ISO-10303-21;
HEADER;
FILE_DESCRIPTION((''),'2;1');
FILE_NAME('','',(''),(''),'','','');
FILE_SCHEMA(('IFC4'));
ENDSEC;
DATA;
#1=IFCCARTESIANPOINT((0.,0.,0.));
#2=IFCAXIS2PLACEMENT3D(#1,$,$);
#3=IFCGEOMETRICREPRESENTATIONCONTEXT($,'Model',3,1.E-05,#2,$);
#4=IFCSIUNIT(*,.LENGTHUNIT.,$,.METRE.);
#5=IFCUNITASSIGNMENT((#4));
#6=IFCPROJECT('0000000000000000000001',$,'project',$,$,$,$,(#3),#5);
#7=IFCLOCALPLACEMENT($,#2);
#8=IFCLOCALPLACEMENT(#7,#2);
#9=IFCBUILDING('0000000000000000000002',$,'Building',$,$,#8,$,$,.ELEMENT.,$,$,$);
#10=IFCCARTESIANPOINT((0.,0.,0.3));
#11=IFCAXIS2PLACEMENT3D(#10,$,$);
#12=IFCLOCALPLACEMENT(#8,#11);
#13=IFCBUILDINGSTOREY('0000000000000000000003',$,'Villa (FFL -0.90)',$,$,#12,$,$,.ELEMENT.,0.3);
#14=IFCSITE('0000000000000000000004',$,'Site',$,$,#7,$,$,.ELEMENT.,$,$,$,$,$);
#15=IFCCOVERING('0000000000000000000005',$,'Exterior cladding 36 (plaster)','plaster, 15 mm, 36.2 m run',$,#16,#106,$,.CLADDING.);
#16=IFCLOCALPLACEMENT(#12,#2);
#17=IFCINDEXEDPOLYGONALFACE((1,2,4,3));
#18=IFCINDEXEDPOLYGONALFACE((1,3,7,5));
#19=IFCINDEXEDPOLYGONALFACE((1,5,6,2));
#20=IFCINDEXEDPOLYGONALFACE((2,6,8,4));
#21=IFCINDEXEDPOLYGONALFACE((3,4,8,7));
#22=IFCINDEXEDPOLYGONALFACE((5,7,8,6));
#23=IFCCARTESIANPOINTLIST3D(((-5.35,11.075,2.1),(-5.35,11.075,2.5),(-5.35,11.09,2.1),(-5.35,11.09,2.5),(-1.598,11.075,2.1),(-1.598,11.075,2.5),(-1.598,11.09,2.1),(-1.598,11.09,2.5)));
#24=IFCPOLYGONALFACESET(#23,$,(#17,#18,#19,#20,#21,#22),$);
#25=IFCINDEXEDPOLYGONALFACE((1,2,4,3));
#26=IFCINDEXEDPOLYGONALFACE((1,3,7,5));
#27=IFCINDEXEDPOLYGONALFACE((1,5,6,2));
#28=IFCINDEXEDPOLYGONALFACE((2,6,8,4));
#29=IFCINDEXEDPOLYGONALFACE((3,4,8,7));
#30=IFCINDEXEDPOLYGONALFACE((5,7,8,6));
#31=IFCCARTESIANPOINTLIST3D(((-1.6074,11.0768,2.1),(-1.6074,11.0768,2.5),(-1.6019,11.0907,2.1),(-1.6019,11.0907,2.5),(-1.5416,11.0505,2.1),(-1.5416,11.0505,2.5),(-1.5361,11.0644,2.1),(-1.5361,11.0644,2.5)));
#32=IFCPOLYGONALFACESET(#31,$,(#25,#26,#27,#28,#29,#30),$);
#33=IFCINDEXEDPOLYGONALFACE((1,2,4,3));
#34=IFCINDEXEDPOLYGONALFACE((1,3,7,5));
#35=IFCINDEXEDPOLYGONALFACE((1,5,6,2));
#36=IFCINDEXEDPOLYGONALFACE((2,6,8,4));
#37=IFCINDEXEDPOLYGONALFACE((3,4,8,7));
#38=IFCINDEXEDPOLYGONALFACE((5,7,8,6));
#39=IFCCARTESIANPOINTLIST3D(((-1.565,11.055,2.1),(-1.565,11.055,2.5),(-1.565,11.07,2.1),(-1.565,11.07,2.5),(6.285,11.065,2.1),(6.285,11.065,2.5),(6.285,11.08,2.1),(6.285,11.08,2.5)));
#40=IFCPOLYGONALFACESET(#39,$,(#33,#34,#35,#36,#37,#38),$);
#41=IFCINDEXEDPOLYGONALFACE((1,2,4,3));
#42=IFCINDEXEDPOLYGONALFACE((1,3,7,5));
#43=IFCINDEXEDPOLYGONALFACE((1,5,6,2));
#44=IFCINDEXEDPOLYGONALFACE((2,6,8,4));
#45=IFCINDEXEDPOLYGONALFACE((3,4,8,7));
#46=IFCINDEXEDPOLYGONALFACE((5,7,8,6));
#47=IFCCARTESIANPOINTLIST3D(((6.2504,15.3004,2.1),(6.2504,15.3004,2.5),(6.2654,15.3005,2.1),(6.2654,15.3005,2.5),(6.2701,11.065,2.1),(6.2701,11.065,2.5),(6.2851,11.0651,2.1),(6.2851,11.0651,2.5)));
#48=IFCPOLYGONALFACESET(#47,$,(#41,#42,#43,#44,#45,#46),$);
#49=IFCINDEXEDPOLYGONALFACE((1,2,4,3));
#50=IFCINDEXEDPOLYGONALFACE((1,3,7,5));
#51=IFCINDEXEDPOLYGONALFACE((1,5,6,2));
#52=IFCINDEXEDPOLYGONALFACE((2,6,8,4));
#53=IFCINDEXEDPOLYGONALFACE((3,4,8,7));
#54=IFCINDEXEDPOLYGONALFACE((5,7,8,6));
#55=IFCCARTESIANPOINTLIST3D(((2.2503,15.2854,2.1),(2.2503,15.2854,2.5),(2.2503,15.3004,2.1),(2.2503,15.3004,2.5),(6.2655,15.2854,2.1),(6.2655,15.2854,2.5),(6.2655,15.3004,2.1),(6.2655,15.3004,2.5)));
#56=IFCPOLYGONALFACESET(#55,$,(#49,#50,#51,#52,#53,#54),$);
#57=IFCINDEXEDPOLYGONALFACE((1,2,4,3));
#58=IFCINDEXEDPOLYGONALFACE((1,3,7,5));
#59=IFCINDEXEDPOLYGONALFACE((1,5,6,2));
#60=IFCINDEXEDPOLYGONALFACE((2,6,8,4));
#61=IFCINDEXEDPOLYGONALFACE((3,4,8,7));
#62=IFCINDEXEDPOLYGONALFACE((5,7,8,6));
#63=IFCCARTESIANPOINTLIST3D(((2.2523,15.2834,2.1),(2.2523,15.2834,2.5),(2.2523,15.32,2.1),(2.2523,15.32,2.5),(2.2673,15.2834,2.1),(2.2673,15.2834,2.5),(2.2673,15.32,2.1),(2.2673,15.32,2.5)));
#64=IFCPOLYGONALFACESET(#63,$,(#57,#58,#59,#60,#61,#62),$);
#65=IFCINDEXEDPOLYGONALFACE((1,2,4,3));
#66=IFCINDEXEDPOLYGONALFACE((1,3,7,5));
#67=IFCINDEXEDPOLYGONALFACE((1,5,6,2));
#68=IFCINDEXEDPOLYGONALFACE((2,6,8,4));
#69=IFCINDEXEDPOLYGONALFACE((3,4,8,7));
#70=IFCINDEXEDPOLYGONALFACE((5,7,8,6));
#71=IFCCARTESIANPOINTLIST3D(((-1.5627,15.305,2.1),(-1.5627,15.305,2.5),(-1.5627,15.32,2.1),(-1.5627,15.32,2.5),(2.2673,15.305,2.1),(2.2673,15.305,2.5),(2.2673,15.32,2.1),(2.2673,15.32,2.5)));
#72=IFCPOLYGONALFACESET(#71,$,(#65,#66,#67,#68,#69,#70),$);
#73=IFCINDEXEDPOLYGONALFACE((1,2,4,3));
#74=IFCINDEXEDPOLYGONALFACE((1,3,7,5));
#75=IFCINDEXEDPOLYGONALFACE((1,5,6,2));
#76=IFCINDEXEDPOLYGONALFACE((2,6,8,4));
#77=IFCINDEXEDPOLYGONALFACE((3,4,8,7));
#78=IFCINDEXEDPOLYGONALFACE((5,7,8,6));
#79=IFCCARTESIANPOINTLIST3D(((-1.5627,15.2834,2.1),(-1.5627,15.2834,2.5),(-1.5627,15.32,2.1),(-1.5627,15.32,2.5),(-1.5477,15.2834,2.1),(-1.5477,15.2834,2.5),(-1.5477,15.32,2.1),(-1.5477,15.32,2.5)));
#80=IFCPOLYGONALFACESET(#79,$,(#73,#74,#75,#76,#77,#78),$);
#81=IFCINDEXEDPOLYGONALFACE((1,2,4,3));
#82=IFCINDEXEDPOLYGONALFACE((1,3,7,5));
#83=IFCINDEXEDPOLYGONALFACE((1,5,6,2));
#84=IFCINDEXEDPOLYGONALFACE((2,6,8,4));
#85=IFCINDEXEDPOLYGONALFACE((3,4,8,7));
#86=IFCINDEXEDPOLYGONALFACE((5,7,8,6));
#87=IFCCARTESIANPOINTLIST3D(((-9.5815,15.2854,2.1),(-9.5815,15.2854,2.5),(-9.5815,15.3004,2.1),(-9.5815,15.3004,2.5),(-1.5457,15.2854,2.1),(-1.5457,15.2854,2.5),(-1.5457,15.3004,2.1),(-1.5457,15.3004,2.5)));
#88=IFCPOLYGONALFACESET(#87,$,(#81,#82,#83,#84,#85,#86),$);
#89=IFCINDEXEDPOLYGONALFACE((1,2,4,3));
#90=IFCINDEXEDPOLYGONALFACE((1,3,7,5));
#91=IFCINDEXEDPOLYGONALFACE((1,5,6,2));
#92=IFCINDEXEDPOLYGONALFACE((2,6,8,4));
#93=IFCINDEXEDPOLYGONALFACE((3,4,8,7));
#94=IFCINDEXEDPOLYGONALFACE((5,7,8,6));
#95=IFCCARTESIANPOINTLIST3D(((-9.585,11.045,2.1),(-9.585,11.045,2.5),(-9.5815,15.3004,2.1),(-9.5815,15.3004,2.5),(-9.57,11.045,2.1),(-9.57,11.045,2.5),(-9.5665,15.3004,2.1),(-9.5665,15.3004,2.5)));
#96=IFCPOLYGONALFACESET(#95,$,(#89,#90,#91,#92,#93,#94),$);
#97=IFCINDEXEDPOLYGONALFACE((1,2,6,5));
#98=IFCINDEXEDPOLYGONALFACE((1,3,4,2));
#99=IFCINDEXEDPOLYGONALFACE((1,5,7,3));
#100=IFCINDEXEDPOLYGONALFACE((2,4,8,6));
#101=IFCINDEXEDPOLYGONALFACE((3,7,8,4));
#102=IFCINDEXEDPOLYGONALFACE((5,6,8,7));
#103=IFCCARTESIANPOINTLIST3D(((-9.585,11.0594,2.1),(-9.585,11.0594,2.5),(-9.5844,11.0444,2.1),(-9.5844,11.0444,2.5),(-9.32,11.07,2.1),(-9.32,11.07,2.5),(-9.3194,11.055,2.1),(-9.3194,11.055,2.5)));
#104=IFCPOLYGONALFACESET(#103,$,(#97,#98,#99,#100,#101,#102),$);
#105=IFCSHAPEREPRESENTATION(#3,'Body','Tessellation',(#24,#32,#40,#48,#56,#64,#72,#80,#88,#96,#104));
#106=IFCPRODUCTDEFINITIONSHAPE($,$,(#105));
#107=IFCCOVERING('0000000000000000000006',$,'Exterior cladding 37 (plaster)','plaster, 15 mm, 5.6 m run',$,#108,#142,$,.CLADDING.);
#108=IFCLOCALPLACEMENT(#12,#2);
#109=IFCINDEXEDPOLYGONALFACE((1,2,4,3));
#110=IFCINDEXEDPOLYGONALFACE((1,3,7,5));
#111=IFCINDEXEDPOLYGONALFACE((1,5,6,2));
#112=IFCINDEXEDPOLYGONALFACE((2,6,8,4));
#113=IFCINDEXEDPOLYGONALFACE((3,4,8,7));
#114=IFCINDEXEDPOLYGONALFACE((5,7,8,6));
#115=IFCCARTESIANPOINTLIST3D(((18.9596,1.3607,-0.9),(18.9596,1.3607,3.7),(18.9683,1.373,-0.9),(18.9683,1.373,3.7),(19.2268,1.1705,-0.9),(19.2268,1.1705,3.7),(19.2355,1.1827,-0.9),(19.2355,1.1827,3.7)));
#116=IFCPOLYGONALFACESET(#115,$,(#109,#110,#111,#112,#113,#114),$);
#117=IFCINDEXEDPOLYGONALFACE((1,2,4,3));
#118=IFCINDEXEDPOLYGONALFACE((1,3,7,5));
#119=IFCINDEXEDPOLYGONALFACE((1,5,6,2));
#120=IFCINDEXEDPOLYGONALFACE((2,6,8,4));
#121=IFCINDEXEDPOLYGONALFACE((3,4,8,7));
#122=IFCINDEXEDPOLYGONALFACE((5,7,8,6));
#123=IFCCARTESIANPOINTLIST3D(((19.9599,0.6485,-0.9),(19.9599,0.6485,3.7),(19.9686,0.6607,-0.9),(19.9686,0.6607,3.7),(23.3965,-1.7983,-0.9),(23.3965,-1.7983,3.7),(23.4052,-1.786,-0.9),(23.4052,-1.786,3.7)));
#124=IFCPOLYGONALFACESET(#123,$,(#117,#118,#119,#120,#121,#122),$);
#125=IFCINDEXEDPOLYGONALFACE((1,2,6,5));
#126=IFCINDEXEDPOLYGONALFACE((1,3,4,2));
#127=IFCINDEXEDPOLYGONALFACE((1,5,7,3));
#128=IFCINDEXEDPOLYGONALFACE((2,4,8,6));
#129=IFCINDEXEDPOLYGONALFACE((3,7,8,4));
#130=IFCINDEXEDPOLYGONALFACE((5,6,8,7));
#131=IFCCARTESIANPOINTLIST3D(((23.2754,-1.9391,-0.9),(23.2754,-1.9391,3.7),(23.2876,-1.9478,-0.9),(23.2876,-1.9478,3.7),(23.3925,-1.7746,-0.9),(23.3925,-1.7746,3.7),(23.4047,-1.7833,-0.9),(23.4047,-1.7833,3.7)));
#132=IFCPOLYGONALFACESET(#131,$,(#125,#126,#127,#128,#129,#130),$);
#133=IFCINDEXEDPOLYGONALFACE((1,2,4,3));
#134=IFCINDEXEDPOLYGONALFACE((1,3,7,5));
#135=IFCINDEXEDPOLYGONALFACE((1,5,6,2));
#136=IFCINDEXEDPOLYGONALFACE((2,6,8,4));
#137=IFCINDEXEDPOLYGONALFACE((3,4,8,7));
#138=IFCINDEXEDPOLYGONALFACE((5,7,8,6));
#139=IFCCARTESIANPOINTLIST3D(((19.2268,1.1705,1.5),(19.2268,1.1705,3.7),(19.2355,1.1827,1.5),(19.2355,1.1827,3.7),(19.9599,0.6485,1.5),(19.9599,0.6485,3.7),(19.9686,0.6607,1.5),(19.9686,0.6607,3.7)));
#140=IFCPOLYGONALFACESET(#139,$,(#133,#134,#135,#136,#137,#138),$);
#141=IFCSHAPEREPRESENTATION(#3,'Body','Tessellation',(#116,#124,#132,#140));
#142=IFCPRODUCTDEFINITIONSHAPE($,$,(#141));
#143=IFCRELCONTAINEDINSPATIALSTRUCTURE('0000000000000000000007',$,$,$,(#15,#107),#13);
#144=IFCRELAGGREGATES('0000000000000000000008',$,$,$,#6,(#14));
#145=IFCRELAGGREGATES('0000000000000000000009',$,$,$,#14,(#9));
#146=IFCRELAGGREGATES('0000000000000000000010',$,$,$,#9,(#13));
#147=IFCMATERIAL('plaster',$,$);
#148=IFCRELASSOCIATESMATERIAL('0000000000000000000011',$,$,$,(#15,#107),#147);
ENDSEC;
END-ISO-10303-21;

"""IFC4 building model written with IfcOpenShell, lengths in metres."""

from ifc_helpers import new_model, si_unit, frame, origin, origin_with_axes, place, context, project, spatial, polyline, outline, extrude, material, element, save


model = new_model("IFC4")

# Units and contexts
model_context = context("Model", 3, precision=1e-05, world=origin())
ifc_project = project(units=[si_unit("LENGTHUNIT", "METRE")], contexts=[model_context])

# Site, building, storey
site_placement = place(None, origin())
site = spatial("IfcSite", under=ifc_project, at=site_placement, Name="Site", CompositionType="ELEMENT")
building_placement = place(site_placement, origin())
building = spatial("IfcBuilding", under=site, at=building_placement, Name="Building", CompositionType="ELEMENT")
storey_placement = place(building_placement, frame((0.0, 0.0, 0.3)))
storey = spatial("IfcBuildingStorey", under=building, at=storey_placement, Name="Villa (FFL -0.90)", CompositionType="ELEMENT", Elevation=0.3)

# Coverings
ifc_material = material(Name="plaster")
covering_1_placement = place(storey_placement, origin_with_axes())
element("IfcCovering", 1, at=covering_1_placement, inside=storey, material=ifc_material, Name="Exterior cladding 36 (plaster)", Description="plaster, 15 mm, 36.2 m run", PredefinedType="CLADDING", context=model_context, shape_type="SweptSolid", body=[
    extrude(outline(polyline([(-5.35, 11.075), (-1.598, 11.075), (-1.598, 11.09), (-5.35, 11.09), (-5.35, 11.075)])), frame((0.0, 0.0, 2.1)), (0.0, 0.0, 1.0), 0.4),
    extrude(outline(polyline([(-1.6074, 11.0768), (-1.5416, 11.0505), (-1.5361, 11.0644), (-1.6019, 11.0907), (-1.6074, 11.0768)])), frame((0.0, 0.0, 2.1)), (0.0, 0.0, 1.0), 0.4),
    extrude(outline(polyline([(-1.565, 11.055), (6.285, 11.065), (6.285, 11.08), (-1.565, 11.07), (-1.565, 11.055)])), frame((0.0, 0.0, 2.1)), (0.0, 0.0, 1.0), 0.4),
    extrude(outline(polyline([(6.2851, 11.0651), (6.2654, 15.3005), (6.2504, 15.3004), (6.2701, 11.065), (6.2851, 11.0651)])), frame((0.0, 0.0, 2.1)), (0.0, 0.0, 1.0), 0.4),
    extrude(outline(polyline([(6.2655, 15.3004), (2.2503, 15.3004), (2.2503, 15.2854), (6.2655, 15.2854), (6.2655, 15.3004)])), frame((0.0, 0.0, 2.1)), (0.0, 0.0, 1.0), 0.4),
    extrude(outline(polyline([(2.2673, 15.2834), (2.2673, 15.32), (2.2523, 15.32), (2.2523, 15.2834), (2.2673, 15.2834)])), frame((0.0, 0.0, 2.1)), (0.0, 0.0, 1.0), 0.4),
    extrude(outline(polyline([(2.2673, 15.32), (-1.5627, 15.32), (-1.5627, 15.305), (2.2673, 15.305), (2.2673, 15.32)])), frame((0.0, 0.0, 2.1)), (0.0, 0.0, 1.0), 0.4),
    extrude(outline(polyline([(-1.5627, 15.32), (-1.5627, 15.2834), (-1.5477, 15.2834), (-1.5477, 15.32), (-1.5627, 15.32)])), frame((0.0, 0.0, 2.1)), (0.0, 0.0, 1.0), 0.4),
    extrude(outline(polyline([(-1.5457, 15.3004), (-9.5815, 15.3004), (-9.5815, 15.2854), (-1.5457, 15.2854), (-1.5457, 15.3004)])), frame((0.0, 0.0, 2.1)), (0.0, 0.0, 1.0), 0.4),
    extrude(outline(polyline([(-9.5815, 15.3004), (-9.585, 11.045), (-9.57, 11.045), (-9.5665, 15.3004), (-9.5815, 15.3004)])), frame((0.0, 0.0, 2.1)), (0.0, 0.0, 1.0), 0.4),
    extrude(outline(polyline([(-9.5844, 11.0444), (-9.3194, 11.055), (-9.32, 11.07), (-9.585, 11.0594), (-9.5844, 11.0444)])), frame((0.0, 0.0, 2.1)), (0.0, 0.0, 1.0), 0.4),
])
covering_2_placement = place(storey_placement, origin_with_axes())
element("IfcCovering", 2, at=covering_2_placement, inside=storey, material=ifc_material, Name="Exterior cladding 37 (plaster)", Description="plaster, 15 mm, 5.6 m run", PredefinedType="CLADDING", context=model_context, shape_type="SweptSolid", body=[
    extrude(outline(polyline([(18.9596, 1.3607), (19.2268, 1.1705), (19.2355, 1.1827), (18.9683, 1.373), (18.9596, 1.3607)])), frame((0.0, 0.0, -0.9)), (0.0, 0.0, 1.0), 4.6),
    extrude(outline(polyline([(19.9599, 0.6485), (23.3965, -1.7983), (23.4052, -1.786), (19.9686, 0.6607), (19.9599, 0.6485)])), frame((0.0, 0.0, -0.9)), (0.0, 0.0, 1.0), 4.6),
    extrude(outline(polyline([(23.3925, -1.7746), (23.2754, -1.9391), (23.2876, -1.9478), (23.4047, -1.7833), (23.3925, -1.7746)])), frame((0.0, 0.0, -0.9)), (0.0, 0.0, 1.0), 4.6),
    extrude(outline(polyline([(19.2268, 1.1705), (19.9599, 0.6485), (19.9686, 0.6607), (19.2355, 1.1827), (19.2268, 1.1705)])), frame((0.0, 0.0, 1.5)), (0.0, 0.0, 1.0), 2.2),
])

save(model, "model.ifc")
